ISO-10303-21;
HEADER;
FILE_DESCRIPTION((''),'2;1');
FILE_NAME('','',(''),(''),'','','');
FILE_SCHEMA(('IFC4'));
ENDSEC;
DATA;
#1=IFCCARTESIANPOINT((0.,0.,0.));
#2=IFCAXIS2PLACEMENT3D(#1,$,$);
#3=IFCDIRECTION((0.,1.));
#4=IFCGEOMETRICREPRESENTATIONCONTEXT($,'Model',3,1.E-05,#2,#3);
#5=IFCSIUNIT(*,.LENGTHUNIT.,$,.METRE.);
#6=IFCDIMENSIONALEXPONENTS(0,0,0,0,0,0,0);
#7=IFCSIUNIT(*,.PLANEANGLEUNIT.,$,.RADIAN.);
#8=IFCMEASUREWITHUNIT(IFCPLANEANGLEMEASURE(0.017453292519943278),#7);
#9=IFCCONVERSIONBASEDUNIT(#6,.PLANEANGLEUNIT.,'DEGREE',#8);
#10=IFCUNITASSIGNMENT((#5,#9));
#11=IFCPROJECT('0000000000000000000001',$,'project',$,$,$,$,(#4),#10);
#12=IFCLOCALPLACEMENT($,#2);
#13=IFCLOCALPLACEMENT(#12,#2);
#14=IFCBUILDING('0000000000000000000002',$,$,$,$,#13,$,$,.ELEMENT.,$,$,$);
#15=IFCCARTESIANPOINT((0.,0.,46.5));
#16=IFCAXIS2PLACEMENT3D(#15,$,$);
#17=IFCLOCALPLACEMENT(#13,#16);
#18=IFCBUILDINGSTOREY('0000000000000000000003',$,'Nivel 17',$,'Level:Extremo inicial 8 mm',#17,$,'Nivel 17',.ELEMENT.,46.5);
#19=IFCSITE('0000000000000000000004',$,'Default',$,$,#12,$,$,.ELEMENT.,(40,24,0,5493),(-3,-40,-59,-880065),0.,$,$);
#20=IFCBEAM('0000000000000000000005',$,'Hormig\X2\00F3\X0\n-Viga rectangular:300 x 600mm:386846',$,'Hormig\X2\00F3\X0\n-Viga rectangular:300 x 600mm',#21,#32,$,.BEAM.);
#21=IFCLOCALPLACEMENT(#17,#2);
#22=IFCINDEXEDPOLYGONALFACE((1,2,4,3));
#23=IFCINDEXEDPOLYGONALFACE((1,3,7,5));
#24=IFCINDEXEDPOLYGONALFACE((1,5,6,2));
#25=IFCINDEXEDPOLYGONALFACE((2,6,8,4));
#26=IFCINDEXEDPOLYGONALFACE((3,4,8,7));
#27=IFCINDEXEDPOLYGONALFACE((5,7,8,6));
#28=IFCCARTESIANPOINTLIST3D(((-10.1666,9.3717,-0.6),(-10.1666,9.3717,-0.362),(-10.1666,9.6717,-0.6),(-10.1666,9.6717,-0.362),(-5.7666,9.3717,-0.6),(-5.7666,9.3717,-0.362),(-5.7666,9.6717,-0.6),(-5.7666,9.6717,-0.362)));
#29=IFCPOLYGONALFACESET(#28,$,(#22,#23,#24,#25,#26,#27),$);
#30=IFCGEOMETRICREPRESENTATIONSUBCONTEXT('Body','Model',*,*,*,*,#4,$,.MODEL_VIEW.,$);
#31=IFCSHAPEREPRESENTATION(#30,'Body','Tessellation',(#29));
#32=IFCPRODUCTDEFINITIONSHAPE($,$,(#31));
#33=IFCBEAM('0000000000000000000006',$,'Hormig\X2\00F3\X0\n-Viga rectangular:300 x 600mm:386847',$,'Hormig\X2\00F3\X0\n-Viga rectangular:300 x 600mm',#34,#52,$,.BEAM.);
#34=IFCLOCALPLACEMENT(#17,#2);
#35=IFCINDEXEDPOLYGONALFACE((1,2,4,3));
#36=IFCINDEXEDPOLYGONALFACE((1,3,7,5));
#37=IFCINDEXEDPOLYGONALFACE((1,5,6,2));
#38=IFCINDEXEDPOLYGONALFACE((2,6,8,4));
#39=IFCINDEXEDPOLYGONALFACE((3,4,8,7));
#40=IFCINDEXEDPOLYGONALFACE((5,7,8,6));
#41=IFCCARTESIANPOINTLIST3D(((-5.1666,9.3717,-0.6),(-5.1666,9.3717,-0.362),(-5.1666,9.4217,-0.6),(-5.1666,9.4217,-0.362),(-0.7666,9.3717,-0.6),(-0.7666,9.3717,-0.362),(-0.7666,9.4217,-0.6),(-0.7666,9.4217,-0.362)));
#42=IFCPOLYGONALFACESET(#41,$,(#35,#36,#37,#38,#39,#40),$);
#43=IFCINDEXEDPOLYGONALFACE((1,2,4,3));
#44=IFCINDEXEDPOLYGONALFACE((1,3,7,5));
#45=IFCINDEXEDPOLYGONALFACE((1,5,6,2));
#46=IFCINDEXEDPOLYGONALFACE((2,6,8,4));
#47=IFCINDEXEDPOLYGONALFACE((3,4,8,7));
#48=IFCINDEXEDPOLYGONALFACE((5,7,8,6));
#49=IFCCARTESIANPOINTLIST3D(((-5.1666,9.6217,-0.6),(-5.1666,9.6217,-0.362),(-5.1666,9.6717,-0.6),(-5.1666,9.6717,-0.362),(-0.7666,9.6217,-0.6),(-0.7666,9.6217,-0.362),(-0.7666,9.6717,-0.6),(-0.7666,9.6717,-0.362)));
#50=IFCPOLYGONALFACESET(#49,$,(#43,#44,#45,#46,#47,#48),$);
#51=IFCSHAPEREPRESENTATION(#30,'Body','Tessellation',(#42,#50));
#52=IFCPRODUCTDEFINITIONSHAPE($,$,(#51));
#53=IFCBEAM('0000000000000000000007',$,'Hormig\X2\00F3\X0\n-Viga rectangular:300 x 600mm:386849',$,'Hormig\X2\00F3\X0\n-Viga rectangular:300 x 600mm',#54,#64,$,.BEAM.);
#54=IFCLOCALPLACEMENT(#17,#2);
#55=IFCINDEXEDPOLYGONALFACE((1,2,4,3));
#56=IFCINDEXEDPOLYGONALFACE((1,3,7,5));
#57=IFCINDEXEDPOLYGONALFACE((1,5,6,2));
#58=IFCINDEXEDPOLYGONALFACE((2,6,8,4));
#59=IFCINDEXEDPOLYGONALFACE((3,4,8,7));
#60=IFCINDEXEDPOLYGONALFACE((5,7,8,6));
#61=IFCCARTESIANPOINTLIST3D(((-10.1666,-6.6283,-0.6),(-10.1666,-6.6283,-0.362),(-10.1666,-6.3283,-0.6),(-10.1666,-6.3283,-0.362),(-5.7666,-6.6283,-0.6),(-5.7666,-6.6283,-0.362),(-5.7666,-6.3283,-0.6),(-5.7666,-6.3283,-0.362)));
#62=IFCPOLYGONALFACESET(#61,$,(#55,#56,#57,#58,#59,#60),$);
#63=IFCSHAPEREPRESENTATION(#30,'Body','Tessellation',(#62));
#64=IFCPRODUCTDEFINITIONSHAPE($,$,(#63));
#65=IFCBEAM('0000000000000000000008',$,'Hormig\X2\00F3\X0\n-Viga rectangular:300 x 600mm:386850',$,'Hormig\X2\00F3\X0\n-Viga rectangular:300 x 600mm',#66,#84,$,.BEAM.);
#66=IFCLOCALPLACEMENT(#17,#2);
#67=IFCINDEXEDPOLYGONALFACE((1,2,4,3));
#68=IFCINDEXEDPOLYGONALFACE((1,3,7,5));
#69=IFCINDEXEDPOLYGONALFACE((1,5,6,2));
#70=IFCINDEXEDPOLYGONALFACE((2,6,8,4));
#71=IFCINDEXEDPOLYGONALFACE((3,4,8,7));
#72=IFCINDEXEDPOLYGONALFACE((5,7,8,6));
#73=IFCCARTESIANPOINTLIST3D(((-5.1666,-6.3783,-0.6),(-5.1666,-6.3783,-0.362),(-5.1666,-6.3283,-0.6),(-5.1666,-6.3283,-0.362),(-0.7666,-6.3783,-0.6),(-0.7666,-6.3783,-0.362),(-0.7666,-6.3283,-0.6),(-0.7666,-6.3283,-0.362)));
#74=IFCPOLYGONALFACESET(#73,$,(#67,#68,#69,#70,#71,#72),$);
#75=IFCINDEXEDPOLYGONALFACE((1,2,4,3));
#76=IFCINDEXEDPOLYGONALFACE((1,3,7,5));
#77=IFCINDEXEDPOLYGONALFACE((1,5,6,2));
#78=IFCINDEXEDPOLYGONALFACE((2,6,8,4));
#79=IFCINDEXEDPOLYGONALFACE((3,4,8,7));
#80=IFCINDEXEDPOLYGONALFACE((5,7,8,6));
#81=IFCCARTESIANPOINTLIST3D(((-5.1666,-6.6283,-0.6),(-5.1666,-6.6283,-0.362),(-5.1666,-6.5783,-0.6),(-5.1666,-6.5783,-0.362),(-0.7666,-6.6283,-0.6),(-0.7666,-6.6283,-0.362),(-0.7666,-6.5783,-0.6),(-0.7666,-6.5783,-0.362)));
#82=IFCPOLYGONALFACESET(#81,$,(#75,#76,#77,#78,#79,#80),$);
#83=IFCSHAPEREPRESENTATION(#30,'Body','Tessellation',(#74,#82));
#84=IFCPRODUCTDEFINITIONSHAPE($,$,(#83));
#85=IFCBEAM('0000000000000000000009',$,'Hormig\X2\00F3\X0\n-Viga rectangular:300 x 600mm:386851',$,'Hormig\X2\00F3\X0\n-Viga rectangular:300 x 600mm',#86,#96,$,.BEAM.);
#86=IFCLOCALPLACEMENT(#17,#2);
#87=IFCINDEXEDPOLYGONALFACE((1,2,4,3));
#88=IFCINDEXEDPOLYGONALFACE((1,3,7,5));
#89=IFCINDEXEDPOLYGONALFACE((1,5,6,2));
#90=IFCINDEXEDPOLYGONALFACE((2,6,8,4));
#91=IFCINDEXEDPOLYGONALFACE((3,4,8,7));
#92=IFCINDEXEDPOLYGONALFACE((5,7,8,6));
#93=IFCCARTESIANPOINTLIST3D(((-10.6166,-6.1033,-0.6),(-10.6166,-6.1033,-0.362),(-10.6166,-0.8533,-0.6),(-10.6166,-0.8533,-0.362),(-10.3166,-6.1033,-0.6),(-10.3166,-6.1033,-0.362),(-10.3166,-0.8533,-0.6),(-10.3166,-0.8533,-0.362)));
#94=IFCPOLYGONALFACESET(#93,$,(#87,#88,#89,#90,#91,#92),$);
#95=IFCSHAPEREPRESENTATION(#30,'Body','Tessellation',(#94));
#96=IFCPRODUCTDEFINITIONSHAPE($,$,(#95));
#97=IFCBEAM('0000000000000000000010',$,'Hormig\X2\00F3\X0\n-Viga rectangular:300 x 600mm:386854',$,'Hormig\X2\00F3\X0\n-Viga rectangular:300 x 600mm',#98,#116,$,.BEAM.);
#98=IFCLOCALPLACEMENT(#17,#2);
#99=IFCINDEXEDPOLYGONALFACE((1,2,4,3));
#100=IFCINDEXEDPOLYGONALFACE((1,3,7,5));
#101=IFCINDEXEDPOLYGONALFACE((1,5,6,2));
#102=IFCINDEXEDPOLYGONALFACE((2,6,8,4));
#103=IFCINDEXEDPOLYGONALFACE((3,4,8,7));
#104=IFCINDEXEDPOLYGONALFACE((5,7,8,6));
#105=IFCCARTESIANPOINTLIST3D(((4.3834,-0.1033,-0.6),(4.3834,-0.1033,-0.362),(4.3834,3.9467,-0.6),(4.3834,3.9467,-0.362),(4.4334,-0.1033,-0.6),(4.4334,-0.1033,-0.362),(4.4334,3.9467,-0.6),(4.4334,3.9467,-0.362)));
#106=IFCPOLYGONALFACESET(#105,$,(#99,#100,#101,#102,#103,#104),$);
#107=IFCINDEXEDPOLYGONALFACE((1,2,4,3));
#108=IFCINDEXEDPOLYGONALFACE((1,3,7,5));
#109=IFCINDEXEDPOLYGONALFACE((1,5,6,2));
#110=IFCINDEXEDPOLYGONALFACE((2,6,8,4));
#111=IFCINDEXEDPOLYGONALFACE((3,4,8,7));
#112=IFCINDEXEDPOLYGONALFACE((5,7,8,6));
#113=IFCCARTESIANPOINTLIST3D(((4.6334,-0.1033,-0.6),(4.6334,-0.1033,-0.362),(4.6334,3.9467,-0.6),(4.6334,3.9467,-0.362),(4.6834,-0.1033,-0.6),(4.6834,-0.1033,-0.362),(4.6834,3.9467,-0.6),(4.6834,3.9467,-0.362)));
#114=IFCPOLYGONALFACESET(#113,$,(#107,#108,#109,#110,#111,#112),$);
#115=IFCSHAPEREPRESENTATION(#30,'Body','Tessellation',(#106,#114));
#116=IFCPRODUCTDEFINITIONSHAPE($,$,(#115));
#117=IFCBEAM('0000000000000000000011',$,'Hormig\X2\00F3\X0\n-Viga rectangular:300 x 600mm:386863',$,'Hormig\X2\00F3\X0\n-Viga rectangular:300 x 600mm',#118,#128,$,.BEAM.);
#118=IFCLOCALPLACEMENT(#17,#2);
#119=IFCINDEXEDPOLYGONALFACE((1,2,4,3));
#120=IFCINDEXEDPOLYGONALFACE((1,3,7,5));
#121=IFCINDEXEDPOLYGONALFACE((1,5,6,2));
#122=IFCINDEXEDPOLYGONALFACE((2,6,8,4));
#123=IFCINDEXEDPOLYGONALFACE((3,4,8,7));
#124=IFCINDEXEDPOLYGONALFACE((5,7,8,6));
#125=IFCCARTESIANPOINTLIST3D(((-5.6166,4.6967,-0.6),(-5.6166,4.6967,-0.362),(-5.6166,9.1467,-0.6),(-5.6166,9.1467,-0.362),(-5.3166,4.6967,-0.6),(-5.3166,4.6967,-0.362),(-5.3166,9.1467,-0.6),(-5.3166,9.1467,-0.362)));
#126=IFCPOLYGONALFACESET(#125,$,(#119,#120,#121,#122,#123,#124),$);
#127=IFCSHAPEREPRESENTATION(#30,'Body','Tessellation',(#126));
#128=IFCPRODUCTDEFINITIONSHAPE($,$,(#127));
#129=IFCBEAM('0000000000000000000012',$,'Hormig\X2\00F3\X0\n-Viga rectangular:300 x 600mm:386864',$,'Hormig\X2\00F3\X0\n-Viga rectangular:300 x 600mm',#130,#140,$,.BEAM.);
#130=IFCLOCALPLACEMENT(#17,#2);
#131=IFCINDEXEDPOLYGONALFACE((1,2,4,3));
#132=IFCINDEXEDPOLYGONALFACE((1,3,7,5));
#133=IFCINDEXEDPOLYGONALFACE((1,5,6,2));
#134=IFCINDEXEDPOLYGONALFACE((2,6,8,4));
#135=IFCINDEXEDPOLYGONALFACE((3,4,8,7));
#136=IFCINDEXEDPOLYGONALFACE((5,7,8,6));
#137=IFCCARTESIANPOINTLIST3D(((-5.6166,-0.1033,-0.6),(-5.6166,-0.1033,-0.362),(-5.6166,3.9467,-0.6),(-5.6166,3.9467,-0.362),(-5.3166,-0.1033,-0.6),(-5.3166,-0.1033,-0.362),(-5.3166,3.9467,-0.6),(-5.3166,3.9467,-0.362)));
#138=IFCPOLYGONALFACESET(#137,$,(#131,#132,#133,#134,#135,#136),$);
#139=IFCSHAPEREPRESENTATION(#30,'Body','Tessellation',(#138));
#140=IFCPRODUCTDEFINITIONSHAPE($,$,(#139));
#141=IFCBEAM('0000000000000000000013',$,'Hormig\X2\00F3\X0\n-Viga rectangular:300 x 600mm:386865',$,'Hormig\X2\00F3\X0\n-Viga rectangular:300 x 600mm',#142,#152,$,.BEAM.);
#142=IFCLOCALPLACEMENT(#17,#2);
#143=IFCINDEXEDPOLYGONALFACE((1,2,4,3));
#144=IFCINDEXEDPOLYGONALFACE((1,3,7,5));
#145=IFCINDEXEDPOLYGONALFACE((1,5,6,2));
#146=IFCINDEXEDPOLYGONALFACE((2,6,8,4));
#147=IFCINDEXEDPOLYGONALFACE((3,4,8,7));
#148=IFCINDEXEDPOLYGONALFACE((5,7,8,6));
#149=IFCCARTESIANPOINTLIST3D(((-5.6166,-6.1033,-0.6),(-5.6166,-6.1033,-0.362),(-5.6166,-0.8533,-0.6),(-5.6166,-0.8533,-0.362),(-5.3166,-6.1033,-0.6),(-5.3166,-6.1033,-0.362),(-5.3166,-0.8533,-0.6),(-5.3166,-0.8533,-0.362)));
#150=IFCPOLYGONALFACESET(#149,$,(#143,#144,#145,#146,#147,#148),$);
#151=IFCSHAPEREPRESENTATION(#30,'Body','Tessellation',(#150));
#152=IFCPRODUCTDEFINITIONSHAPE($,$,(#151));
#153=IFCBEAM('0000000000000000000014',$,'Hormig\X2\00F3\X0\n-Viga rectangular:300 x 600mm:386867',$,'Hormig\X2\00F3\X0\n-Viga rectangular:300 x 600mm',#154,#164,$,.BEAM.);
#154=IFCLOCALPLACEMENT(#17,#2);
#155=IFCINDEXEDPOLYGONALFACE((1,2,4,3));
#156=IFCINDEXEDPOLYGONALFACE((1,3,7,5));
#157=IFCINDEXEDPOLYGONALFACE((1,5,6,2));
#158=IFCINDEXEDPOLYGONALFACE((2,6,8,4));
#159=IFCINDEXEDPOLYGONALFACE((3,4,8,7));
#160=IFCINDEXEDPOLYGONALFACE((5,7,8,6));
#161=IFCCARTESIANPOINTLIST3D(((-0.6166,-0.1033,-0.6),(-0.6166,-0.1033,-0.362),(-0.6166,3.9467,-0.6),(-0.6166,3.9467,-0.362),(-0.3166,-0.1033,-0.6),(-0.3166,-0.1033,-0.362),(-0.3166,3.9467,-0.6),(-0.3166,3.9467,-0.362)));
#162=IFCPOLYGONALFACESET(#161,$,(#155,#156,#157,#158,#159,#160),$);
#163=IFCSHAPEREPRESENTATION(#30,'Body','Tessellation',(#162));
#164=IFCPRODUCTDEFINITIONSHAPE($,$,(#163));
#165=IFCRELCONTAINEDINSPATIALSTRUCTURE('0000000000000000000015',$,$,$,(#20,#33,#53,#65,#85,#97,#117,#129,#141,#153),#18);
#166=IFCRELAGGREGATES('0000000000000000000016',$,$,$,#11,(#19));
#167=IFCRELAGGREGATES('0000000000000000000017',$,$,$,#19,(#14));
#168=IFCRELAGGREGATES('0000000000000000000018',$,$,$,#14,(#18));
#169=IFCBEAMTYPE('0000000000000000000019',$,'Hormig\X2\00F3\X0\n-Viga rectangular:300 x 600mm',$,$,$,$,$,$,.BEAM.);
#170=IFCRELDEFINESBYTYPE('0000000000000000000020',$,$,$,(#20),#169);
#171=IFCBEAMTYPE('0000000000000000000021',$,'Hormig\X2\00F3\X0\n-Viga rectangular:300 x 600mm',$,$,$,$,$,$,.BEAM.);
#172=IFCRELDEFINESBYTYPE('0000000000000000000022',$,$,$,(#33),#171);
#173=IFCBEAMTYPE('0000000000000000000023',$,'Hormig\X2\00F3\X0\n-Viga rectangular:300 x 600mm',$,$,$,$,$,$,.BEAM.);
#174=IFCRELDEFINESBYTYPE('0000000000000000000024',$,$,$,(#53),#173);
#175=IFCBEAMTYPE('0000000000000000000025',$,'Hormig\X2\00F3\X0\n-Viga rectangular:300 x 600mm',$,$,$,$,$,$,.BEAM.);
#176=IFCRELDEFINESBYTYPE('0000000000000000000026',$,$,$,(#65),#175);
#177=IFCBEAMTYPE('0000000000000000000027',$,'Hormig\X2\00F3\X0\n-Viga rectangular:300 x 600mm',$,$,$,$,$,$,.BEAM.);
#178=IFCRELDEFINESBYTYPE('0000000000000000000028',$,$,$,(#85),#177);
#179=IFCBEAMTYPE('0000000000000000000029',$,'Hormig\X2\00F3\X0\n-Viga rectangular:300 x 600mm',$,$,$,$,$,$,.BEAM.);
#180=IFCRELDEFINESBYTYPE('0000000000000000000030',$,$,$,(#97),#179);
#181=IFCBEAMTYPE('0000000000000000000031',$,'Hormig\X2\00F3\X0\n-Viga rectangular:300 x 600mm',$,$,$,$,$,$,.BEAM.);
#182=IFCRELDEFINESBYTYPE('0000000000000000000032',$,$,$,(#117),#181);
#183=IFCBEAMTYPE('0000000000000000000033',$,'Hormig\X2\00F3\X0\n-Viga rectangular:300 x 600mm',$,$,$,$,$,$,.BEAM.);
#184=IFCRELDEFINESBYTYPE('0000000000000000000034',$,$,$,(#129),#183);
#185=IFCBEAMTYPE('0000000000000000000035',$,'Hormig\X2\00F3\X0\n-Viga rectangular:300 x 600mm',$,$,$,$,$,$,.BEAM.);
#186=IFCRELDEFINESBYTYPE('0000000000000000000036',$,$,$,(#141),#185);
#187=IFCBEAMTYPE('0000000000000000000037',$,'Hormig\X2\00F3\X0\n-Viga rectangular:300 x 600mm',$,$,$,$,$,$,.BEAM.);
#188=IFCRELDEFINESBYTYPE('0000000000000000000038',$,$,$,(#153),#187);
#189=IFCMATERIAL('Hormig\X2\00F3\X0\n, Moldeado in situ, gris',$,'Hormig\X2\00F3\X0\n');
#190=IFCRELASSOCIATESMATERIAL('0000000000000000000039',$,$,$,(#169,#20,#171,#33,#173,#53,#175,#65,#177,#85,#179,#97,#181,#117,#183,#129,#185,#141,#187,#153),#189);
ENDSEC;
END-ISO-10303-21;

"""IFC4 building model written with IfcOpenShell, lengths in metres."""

from ifc_helpers import new_model, entity, si_unit, converted_unit, direction, frame, origin, place, context, subcontext, project, spatial, indexed_curve, outline, extrude, source, transform, mapped, material, type_object, type_shapes, element, save


model = new_model("IFC4")

# Units and contexts
model_context = context("Model", 3, precision=1e-05, world=origin(), true_north=direction((0.0, 1.0)))
body_context = subcontext(model_context, "Body", "Model", "MODEL_VIEW")
ifc_project = project(units=[si_unit("LENGTHUNIT", "METRE"), converted_unit("PLANEANGLEUNIT", "DEGREE", entity("IfcPlaneAngleMeasure", 0.017453292519943278), si_unit("PLANEANGLEUNIT", "RADIAN"), dimensions=[0, 0, 0, 0, 0, 0, 0])], contexts=[model_context])

# Site, building, storey
site_placement = place(None, origin())
site = spatial("IfcSite", under=ifc_project, at=site_placement, Name="Default", CompositionType="ELEMENT", RefLatitude=(40, 24, 0, 5493), RefLongitude=(-3, -40, -59, -880065), RefElevation=0.0)
building_placement = place(site_placement, origin())
building = spatial("IfcBuilding", under=site, at=building_placement, CompositionType="ELEMENT")
storey_placement = place(building_placement, frame((0.0, 0.0, 46.5)))
storey = spatial("IfcBuildingStorey", under=building, at=storey_placement, Name="Nivel 17", ObjectType="Level:Extremo inicial 8 mm", LongName="Nivel 17", CompositionType="ELEMENT", Elevation=46.5)

# Beams
ifc_material_1 = material(Name="Hormigón, Moldeado in situ, gris", Category="Hormigón")
beam_type_1 = type_object("IfcBeamType", Name="Hormigón-Viga rectangular:300 x 600mm", PredefinedType="BEAM", material=ifc_material_1)
shared_shape_1 = source(origin(), body_context, "Body", "SweptSolid", [
    extrude(outline(indexed_curve([(-0.119, -0.15), (0.119, -0.15), (0.119, 0.15), (-0.119, 0.15), (-0.119, -0.15)], self_intersect=False)), frame((-5.7666, 9.5217, 46.019), z_axis=(-1.0, 0.0, 0.0), x_axis=(0.0, 0.0, -1.0)), (0.0, 0.0, 1.0), 4.4),
])
type_shapes(beam_type_1, [shared_shape_1])
beam_1_placement = place(storey_placement, frame((0.0, 0.0, -46.5)))
element("IfcBeam", 1, at=beam_1_placement, inside=storey, type_object=beam_type_1, material=ifc_material_1, Name="Hormigón-Viga rectangular:300 x 600mm:386846", ObjectType="Hormigón-Viga rectangular:300 x 600mm", PredefinedType="BEAM", context=body_context, shape_type="MappedRepresentation", body=[
    mapped(shared_shape_1, transform((0.0, 0.0, 0.0), scale=1.0)),
])
beam_type_2 = type_object("IfcBeamType", Name="Hormigón-Viga rectangular:300 x 600mm", PredefinedType="BEAM", material=ifc_material_1)
shared_shape_2 = source(origin(), body_context, "Body", "SweptSolid", [
    extrude(outline(indexed_curve([(-0.119, -0.025), (0.119, -0.025), (0.119, 0.025), (-0.119, 0.025), (-0.119, -0.025)], self_intersect=False)), frame((-5.1666, 9.3967, 46.019), z_axis=(1.0, 0.0, 0.0), x_axis=(0.0, 0.0, -1.0)), (0.0, 0.0, 1.0), 4.4),
    extrude(outline(indexed_curve([(-0.119, -0.025), (0.119, -0.025), (0.119, 0.025), (-0.119, 0.025), (-0.119, -0.025)], self_intersect=False)), frame((-5.1666, 9.6467, 46.019), z_axis=(1.0, 0.0, 0.0), x_axis=(0.0, 0.0, -1.0)), (0.0, 0.0, 1.0), 4.4),
])
type_shapes(beam_type_2, [shared_shape_2])
beam_2_placement = place(storey_placement, frame((0.0, 0.0, -46.5)))
element("IfcBeam", 2, at=beam_2_placement, inside=storey, type_object=beam_type_2, material=ifc_material_1, Name="Hormigón-Viga rectangular:300 x 600mm:386847", ObjectType="Hormigón-Viga rectangular:300 x 600mm", PredefinedType="BEAM", context=body_context, shape_type="MappedRepresentation", body=[
    mapped(shared_shape_2, transform((0.0, 0.0, 0.0), scale=1.0)),
])
beam_type_3 = type_object("IfcBeamType", Name="Hormigón-Viga rectangular:300 x 600mm", PredefinedType="BEAM", material=ifc_material_1)
shared_shape_3 = source(origin(), body_context, "Body", "SweptSolid", [
    extrude(outline(indexed_curve([(-0.119, -0.15), (0.119, -0.15), (0.119, 0.15), (-0.119, 0.15), (-0.119, -0.15)], self_intersect=False)), frame((-10.1666, -6.4783, 46.019), z_axis=(1.0, 0.0, 0.0), x_axis=(0.0, 0.0, -1.0)), (0.0, 0.0, 1.0), 4.4),
])
type_shapes(beam_type_3, [shared_shape_3])
beam_3_placement = place(storey_placement, frame((0.0, 0.0, -46.5)))
element("IfcBeam", 3, at=beam_3_placement, inside=storey, type_object=beam_type_3, material=ifc_material_1, Name="Hormigón-Viga rectangular:300 x 600mm:386849", ObjectType="Hormigón-Viga rectangular:300 x 600mm", PredefinedType="BEAM", context=body_context, shape_type="MappedRepresentation", body=[
    mapped(shared_shape_3, transform((0.0, 0.0, 0.0), scale=1.0)),
])
beam_type_4 = type_object("IfcBeamType", Name="Hormigón-Viga rectangular:300 x 600mm", PredefinedType="BEAM", material=ifc_material_1)
shared_shape_4 = source(origin(), body_context, "Body", "SweptSolid", [
    extrude(outline(indexed_curve([(-0.119, -0.025), (0.119, -0.025), (0.119, 0.025), (-0.119, 0.025), (-0.119, -0.025)], self_intersect=False)), frame((-0.7666, -6.3533, 46.019), z_axis=(-1.0, 0.0, 0.0), x_axis=(0.0, 0.0, -1.0)), (0.0, 0.0, 1.0), 4.4),
    extrude(outline(indexed_curve([(-0.119, -0.025), (0.119, -0.025), (0.119, 0.025), (-0.119, 0.025), (-0.119, -0.025)], self_intersect=False)), frame((-0.7666, -6.6033, 46.019), z_axis=(-1.0, 0.0, 0.0), x_axis=(0.0, 0.0, -1.0)), (0.0, 0.0, 1.0), 4.4),
])
type_shapes(beam_type_4, [shared_shape_4])
beam_4_placement = place(storey_placement, frame((0.0, 0.0, -46.5)))
element("IfcBeam", 4, at=beam_4_placement, inside=storey, type_object=beam_type_4, material=ifc_material_1, Name="Hormigón-Viga rectangular:300 x 600mm:386850", ObjectType="Hormigón-Viga rectangular:300 x 600mm", PredefinedType="BEAM", context=body_context, shape_type="MappedRepresentation", body=[
    mapped(shared_shape_4, transform((0.0, 0.0, 0.0), scale=1.0)),
])
beam_type_5 = type_object("IfcBeamType", Name="Hormigón-Viga rectangular:300 x 600mm", PredefinedType="BEAM", material=ifc_material_1)
shared_shape_5 = source(origin(), body_context, "Body", "SweptSolid", [
    extrude(outline(indexed_curve([(-0.15, -0.119), (0.15, -0.119), (0.15, 0.119), (-0.15, 0.119), (-0.15, -0.119)], self_intersect=False)), frame((-10.4666, -6.1033, 46.019), z_axis=(0.0, 1.0, 0.0), x_axis=(-1.0, 0.0, 0.0)), (0.0, 0.0, 1.0), 5.25),
])
type_shapes(beam_type_5, [shared_shape_5])
beam_5_placement = place(storey_placement, frame((0.0, 0.0, -46.5)))
element("IfcBeam", 5, at=beam_5_placement, inside=storey, type_object=beam_type_5, material=ifc_material_1, Name="Hormigón-Viga rectangular:300 x 600mm:386851", ObjectType="Hormigón-Viga rectangular:300 x 600mm", PredefinedType="BEAM", context=body_context, shape_type="MappedRepresentation", body=[
    mapped(shared_shape_5, transform((0.0, 0.0, 0.0), scale=1.0)),
])
beam_type_6 = type_object("IfcBeamType", Name="Hormigón-Viga rectangular:300 x 600mm", PredefinedType="BEAM", material=ifc_material_1)
shared_shape_6 = source(origin(), body_context, "Body", "SweptSolid", [
    extrude(outline(indexed_curve([(-0.025, -0.119), (0.025, -0.119), (0.025, 0.119), (-0.025, 0.119), (-0.025, -0.119)], self_intersect=False)), frame((4.4084, 3.9467, 46.019), z_axis=(0.0, -1.0, 0.0), x_axis=(-1.0, 0.0, 0.0)), (0.0, 0.0, 1.0), 4.05),
    extrude(outline(indexed_curve([(-0.025, -0.119), (0.025, -0.119), (0.025, 0.119), (-0.025, 0.119), (-0.025, -0.119)], self_intersect=False)), frame((4.6584, 3.9467, 46.019), z_axis=(0.0, -1.0, 0.0), x_axis=(-1.0, 0.0, 0.0)), (0.0, 0.0, 1.0), 4.05),
])
type_shapes(beam_type_6, [shared_shape_6])
beam_6_placement = place(storey_placement, frame((0.0, 0.0, -46.5)))
element("IfcBeam", 6, at=beam_6_placement, inside=storey, type_object=beam_type_6, material=ifc_material_1, Name="Hormigón-Viga rectangular:300 x 600mm:386854", ObjectType="Hormigón-Viga rectangular:300 x 600mm", PredefinedType="BEAM", context=body_context, shape_type="MappedRepresentation", body=[
    mapped(shared_shape_6, transform((0.0, 0.0, 0.0), scale=1.0)),
])
beam_type_7 = type_object("IfcBeamType", Name="Hormigón-Viga rectangular:300 x 600mm", PredefinedType="BEAM", material=ifc_material_1)
shared_shape_7 = source(origin(), body_context, "Body", "SweptSolid", [
    extrude(outline(indexed_curve([(-0.15, -0.119), (0.15, -0.119), (0.15, 0.119), (-0.15, 0.119), (-0.15, -0.119)], self_intersect=False)), frame((-5.4666, 9.1467, 46.019), z_axis=(0.0, -1.0, 0.0), x_axis=(-1.0, 0.0, 0.0)), (0.0, 0.0, 1.0), 4.45),
])
type_shapes(beam_type_7, [shared_shape_7])
beam_7_placement = place(storey_placement, frame((0.0, 0.0, -46.5)))
element("IfcBeam", 7, at=beam_7_placement, inside=storey, type_object=beam_type_7, material=ifc_material_1, Name="Hormigón-Viga rectangular:300 x 600mm:386863", ObjectType="Hormigón-Viga rectangular:300 x 600mm", PredefinedType="BEAM", context=body_context, shape_type="MappedRepresentation", body=[
    mapped(shared_shape_7, transform((0.0, 0.0, 0.0), scale=1.0)),
])
beam_type_8 = type_object("IfcBeamType", Name="Hormigón-Viga rectangular:300 x 600mm", PredefinedType="BEAM", material=ifc_material_1)
shared_shape_8 = source(origin(), body_context, "Body", "SweptSolid", [
    extrude(outline(indexed_curve([(-0.15, -0.119), (0.15, -0.119), (0.15, 0.119), (-0.15, 0.119), (-0.15, -0.119)], self_intersect=False)), frame((-5.4666, 3.9467, 46.019), z_axis=(0.0, -1.0, 0.0), x_axis=(-1.0, 0.0, 0.0)), (0.0, 0.0, 1.0), 4.05),
])
type_shapes(beam_type_8, [shared_shape_8])
beam_8_placement = place(storey_placement, frame((0.0, 0.0, -46.5)))
element("IfcBeam", 8, at=beam_8_placement, inside=storey, type_object=beam_type_8, material=ifc_material_1, Name="Hormigón-Viga rectangular:300 x 600mm:386864", ObjectType="Hormigón-Viga rectangular:300 x 600mm", PredefinedType="BEAM", context=body_context, shape_type="MappedRepresentation", body=[
    mapped(shared_shape_8, transform((0.0, 0.0, 0.0), scale=1.0)),
])
beam_type_9 = type_object("IfcBeamType", Name="Hormigón-Viga rectangular:300 x 600mm", PredefinedType="BEAM", material=ifc_material_1)
shared_shape_9 = source(origin(), body_context, "Body", "SweptSolid", [
    extrude(outline(indexed_curve([(-0.15, -0.119), (0.15, -0.119), (0.15, 0.119), (-0.15, 0.119), (-0.15, -0.119)], self_intersect=False)), frame((-5.4666, -6.1033, 46.019), z_axis=(0.0, 1.0, 0.0), x_axis=(-1.0, 0.0, 0.0)), (0.0, 0.0, 1.0), 5.25),
])
type_shapes(beam_type_9, [shared_shape_9])
beam_9_placement = place(storey_placement, frame((0.0, 0.0, -46.5)))
element("IfcBeam", 9, at=beam_9_placement, inside=storey, type_object=beam_type_9, material=ifc_material_1, Name="Hormigón-Viga rectangular:300 x 600mm:386865", ObjectType="Hormigón-Viga rectangular:300 x 600mm", PredefinedType="BEAM", context=body_context, shape_type="MappedRepresentation", body=[
    mapped(shared_shape_9, transform((0.0, 0.0, 0.0), scale=1.0)),
])
beam_type_10 = type_object("IfcBeamType", Name="Hormigón-Viga rectangular:300 x 600mm", PredefinedType="BEAM", material=ifc_material_1)
shared_shape_10 = source(origin(), body_context, "Body", "SweptSolid", [
    extrude(outline(indexed_curve([(-0.15, -0.119), (0.15, -0.119), (0.15, 0.119), (-0.15, 0.119), (-0.15, -0.119)], self_intersect=False)), frame((-0.4666, -0.1033, 46.019), z_axis=(0.0, 1.0, 0.0), x_axis=(-1.0, 0.0, 0.0)), (0.0, 0.0, 1.0), 4.05),
])
type_shapes(beam_type_10, [shared_shape_10])
beam_10_placement = place(storey_placement, frame((0.0, 0.0, -46.5)))
element("IfcBeam", 10, at=beam_10_placement, inside=storey, type_object=beam_type_10, material=ifc_material_1, Name="Hormigón-Viga rectangular:300 x 600mm:386867", ObjectType="Hormigón-Viga rectangular:300 x 600mm", PredefinedType="BEAM", context=body_context, shape_type="MappedRepresentation", body=[
    mapped(shared_shape_10, transform((0.0, 0.0, 0.0), scale=1.0)),
])

save(model, "model.ifc")
